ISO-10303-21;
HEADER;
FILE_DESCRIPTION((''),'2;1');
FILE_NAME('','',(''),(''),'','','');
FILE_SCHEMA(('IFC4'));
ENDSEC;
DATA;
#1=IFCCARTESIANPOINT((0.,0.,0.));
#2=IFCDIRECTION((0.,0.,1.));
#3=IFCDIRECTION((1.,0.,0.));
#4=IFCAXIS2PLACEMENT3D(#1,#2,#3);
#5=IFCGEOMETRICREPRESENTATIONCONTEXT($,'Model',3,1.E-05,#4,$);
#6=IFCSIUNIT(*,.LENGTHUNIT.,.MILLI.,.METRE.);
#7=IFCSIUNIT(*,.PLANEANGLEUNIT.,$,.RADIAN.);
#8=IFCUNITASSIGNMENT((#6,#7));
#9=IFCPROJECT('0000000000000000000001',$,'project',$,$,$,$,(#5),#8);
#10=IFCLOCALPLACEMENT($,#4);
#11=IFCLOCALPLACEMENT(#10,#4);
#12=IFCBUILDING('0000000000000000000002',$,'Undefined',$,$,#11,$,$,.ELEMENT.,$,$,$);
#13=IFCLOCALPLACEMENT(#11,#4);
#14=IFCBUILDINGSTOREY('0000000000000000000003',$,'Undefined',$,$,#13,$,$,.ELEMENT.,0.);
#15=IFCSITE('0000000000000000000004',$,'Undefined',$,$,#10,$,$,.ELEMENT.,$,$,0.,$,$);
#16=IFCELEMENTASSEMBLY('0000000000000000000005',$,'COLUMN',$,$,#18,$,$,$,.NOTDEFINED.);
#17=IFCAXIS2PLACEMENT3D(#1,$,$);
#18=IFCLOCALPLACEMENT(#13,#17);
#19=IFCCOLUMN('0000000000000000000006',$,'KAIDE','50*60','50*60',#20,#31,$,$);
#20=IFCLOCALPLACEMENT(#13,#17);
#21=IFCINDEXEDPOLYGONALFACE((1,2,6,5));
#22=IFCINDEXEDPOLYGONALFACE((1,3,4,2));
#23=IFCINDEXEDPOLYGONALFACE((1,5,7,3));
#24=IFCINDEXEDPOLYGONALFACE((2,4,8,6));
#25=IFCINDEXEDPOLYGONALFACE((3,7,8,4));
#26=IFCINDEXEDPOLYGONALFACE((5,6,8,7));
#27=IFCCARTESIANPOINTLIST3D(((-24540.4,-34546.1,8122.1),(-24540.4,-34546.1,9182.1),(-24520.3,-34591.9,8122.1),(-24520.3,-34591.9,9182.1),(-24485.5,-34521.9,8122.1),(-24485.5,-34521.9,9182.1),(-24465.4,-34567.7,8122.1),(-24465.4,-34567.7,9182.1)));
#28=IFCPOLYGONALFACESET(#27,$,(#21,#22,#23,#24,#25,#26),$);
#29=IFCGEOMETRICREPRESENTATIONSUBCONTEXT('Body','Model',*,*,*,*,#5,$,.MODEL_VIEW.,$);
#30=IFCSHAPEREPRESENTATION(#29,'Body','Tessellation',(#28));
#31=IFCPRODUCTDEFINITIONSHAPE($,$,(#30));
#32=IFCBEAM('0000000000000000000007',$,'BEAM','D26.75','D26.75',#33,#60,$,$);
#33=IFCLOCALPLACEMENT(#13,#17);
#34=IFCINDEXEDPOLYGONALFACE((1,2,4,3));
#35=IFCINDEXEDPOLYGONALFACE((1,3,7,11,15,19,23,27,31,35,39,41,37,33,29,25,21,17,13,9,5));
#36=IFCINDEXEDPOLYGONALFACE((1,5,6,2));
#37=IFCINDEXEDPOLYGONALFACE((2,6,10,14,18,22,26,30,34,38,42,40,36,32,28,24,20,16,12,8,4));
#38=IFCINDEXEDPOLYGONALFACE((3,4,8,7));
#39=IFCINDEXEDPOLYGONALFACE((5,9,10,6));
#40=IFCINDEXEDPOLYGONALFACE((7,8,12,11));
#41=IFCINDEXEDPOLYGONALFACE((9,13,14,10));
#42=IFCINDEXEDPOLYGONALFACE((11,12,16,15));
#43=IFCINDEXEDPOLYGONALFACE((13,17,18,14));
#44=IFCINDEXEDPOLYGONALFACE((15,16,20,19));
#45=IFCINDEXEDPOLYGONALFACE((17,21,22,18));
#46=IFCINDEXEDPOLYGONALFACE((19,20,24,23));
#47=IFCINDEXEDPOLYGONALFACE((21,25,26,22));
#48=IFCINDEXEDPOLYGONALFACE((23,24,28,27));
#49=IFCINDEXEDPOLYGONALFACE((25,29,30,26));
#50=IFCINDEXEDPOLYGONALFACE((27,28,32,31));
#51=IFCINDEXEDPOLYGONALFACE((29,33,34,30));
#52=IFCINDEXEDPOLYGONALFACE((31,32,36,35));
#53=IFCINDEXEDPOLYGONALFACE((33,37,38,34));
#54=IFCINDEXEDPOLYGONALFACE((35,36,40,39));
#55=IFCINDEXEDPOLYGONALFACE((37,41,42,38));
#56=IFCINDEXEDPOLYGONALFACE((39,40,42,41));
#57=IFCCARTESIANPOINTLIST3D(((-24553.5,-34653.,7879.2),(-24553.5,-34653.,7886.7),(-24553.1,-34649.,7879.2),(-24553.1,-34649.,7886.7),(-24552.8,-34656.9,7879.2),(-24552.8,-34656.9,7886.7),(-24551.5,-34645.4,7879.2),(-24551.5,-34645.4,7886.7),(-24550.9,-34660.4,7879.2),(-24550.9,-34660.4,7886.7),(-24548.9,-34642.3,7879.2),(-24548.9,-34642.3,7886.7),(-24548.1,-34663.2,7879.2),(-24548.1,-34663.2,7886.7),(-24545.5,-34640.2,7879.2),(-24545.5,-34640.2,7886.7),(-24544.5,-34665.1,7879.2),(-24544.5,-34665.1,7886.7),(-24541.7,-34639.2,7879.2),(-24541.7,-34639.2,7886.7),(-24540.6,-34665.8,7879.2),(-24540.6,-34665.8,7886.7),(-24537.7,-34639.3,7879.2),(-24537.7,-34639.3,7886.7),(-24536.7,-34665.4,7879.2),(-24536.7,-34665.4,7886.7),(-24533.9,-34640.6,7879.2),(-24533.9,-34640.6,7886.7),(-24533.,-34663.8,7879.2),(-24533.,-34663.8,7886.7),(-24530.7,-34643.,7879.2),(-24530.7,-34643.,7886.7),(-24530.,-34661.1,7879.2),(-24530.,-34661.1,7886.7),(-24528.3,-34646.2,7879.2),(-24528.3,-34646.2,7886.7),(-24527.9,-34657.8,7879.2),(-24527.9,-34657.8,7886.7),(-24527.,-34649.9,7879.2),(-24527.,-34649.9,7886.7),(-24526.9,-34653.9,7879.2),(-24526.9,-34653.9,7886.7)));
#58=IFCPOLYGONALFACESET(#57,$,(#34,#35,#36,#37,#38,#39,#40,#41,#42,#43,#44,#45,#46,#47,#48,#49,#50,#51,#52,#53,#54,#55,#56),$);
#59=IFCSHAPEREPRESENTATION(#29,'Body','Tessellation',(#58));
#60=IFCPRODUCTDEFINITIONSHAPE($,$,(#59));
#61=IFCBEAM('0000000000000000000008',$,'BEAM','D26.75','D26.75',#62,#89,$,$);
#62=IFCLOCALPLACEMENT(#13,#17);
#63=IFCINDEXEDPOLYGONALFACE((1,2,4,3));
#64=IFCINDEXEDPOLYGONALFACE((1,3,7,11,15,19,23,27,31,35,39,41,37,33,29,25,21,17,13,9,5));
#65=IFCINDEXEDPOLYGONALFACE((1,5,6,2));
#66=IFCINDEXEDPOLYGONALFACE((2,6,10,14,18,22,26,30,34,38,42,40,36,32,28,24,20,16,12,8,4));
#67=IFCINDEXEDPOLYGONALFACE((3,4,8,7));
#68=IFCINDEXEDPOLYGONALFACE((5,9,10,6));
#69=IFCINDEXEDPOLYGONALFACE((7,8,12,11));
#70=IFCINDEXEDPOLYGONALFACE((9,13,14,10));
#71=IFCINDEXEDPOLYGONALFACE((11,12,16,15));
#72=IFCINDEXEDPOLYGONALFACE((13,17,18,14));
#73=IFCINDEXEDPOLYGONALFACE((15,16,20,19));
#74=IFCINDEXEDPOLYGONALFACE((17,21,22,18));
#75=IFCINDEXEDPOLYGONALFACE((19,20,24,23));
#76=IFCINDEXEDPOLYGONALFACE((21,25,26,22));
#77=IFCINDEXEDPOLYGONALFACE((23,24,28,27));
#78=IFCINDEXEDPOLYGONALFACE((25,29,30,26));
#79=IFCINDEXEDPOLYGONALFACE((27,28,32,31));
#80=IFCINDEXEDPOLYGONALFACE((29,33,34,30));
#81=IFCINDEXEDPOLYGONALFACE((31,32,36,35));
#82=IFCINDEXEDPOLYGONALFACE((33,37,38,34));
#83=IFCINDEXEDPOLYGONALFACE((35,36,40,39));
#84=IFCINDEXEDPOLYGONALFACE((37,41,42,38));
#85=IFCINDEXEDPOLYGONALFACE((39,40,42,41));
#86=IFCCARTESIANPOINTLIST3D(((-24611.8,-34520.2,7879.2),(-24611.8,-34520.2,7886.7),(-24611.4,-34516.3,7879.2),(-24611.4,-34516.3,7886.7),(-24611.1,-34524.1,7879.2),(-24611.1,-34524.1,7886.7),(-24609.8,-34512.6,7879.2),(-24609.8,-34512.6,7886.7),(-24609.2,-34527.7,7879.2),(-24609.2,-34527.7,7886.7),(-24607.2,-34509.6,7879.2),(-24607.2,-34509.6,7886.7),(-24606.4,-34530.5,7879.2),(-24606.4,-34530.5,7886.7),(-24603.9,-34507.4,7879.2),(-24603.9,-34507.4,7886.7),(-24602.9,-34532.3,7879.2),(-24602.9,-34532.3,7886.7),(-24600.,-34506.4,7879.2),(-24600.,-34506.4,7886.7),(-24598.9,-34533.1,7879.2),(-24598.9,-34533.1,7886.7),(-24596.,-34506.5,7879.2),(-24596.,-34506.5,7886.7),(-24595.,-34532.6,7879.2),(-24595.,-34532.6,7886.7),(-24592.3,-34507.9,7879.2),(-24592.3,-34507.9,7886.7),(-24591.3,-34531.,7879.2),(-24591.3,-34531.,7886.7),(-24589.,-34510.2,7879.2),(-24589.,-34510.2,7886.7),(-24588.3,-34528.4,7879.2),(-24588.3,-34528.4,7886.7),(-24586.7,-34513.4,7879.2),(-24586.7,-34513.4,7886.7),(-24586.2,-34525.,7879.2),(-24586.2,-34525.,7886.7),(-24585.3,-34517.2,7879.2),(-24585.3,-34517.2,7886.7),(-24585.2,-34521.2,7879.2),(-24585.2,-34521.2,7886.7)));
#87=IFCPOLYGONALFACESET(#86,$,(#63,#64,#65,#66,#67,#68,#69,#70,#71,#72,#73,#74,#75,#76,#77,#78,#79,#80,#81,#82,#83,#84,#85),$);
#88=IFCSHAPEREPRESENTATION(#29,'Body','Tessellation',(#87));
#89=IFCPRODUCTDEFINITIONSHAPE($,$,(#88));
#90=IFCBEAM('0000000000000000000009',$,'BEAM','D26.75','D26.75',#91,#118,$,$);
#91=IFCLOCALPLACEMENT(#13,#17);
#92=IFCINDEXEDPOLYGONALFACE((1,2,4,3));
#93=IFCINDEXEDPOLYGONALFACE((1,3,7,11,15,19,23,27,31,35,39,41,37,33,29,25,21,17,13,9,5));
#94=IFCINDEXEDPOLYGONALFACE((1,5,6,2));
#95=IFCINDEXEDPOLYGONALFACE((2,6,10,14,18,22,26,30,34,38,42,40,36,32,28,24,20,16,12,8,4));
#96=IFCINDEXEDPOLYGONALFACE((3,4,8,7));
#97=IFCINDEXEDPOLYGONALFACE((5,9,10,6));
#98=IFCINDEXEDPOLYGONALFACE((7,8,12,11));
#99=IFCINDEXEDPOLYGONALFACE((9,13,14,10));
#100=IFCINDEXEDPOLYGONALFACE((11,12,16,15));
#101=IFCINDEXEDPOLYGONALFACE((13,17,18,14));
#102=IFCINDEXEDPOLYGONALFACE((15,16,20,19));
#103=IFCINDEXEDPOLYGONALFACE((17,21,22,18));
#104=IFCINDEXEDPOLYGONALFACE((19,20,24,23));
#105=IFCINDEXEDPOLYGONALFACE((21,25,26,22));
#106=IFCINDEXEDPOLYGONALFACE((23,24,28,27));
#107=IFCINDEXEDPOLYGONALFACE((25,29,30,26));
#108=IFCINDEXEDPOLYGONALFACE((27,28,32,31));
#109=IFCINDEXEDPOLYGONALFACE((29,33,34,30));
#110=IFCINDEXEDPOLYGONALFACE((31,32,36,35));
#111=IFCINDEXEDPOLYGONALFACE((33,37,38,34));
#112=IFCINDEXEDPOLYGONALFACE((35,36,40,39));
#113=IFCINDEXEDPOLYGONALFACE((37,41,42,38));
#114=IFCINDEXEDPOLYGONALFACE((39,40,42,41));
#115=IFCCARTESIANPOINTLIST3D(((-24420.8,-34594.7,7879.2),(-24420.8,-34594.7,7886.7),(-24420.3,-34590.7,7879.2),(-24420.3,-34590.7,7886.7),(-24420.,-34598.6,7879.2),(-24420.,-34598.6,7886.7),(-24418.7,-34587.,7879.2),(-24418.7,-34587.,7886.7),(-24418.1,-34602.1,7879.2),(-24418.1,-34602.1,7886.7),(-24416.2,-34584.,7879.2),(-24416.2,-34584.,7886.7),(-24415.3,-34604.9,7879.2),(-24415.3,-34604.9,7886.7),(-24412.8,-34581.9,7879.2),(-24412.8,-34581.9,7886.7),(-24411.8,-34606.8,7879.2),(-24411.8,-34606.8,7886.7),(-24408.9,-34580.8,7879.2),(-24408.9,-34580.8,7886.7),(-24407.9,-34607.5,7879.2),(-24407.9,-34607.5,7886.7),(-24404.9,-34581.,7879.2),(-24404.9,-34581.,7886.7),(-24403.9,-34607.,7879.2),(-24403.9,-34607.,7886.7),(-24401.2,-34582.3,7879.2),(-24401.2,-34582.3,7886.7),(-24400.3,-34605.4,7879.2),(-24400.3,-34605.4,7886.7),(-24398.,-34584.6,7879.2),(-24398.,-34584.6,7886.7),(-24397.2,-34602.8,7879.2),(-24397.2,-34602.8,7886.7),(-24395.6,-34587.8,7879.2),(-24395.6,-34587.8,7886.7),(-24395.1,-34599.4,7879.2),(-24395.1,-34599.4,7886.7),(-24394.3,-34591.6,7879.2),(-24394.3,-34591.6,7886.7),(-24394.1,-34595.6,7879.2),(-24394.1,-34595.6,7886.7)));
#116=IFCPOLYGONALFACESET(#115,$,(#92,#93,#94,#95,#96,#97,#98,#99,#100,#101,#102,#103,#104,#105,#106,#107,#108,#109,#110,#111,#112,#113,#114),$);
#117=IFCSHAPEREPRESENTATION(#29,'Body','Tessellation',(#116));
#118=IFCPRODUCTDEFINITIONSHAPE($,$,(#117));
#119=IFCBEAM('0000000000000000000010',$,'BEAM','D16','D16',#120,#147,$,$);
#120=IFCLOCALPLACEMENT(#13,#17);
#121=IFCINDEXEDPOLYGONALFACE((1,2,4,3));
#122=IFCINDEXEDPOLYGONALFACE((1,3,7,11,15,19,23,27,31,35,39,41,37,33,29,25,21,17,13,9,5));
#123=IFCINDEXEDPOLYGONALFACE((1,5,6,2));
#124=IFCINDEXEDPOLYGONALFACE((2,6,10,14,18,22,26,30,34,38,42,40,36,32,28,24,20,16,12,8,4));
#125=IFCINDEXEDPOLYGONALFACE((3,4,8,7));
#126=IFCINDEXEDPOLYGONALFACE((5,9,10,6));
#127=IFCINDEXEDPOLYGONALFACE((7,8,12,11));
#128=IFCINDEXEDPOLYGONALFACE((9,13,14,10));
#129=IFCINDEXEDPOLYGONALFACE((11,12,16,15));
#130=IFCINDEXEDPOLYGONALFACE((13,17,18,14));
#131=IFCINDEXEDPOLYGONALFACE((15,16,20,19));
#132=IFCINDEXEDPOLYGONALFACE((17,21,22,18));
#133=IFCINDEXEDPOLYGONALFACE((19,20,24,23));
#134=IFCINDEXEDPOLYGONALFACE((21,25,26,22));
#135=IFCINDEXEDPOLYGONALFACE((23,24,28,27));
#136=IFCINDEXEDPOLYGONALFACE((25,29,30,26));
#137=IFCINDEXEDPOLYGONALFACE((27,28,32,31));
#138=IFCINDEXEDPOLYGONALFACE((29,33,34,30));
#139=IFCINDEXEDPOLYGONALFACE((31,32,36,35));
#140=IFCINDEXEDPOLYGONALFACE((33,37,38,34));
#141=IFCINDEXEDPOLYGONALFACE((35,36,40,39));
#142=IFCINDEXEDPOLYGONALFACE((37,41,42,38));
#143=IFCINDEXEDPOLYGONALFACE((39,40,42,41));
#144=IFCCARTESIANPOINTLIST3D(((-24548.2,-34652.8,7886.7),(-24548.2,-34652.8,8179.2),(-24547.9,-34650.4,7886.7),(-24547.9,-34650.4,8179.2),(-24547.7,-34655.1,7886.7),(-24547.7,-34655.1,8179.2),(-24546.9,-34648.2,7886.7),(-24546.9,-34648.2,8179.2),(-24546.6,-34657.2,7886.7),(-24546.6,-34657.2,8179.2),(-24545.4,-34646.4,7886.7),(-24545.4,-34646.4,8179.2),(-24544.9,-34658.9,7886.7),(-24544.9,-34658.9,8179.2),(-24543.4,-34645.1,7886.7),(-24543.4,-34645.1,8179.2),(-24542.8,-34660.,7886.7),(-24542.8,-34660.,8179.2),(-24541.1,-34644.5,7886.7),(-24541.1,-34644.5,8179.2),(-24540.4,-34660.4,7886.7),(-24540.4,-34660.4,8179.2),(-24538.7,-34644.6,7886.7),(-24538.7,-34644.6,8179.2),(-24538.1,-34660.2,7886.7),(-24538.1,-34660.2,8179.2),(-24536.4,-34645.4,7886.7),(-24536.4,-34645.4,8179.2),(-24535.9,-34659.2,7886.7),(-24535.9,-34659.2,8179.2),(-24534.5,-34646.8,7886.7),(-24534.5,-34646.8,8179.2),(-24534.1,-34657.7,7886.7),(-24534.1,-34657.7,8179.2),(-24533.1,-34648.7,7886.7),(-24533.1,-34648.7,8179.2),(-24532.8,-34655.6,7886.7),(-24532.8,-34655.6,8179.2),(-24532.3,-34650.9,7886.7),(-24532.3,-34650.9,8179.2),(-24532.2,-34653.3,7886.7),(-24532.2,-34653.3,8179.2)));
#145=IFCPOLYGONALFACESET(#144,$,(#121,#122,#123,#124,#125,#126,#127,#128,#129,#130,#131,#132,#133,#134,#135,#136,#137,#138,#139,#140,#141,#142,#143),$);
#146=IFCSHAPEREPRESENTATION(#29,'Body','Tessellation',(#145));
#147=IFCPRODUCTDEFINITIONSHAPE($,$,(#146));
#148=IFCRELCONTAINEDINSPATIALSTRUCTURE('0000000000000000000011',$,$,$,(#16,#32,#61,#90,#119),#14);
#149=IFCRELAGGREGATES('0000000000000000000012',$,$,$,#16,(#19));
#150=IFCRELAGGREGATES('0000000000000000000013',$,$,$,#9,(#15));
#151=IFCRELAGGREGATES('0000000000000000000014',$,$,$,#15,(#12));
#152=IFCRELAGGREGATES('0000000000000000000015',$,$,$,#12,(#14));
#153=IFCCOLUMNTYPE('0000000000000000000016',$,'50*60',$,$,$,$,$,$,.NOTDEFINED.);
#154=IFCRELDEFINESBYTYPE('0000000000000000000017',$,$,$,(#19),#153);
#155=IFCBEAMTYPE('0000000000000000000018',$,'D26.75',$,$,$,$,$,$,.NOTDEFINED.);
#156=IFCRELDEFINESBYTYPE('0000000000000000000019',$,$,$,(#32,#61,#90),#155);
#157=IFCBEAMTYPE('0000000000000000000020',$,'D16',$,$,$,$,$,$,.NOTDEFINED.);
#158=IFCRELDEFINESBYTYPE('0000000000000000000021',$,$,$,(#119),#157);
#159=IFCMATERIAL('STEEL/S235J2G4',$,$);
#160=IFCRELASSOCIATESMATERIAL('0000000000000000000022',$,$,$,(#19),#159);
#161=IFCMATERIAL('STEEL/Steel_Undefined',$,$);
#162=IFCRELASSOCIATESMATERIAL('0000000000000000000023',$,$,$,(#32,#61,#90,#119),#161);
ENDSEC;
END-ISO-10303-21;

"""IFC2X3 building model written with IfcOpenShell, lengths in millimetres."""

from ifc_helpers import new_model, si_unit, frame, origin_with_axes, origin_2d_with_axis, place, context, subcontext, project, spatial, rectangle, circle, extrude, material, type_object, element, aggregate, save


model = new_model("IFC2X3")

# Units and contexts
model_context = context("Model", 3, precision=1e-05, world=origin_with_axes())
body_context = subcontext(model_context, "Body", "Model", "MODEL_VIEW")
ifc_project = project(units=[si_unit("LENGTHUNIT", "METRE", prefix="MILLI"), si_unit("PLANEANGLEUNIT", "RADIAN")], contexts=[model_context])

# Site, building, storey
site_placement = place(None, origin_with_axes())
site = spatial("IfcSite", under=ifc_project, at=site_placement, Name="Undefined", CompositionType="ELEMENT", RefElevation=0.0)
building_placement = place(site_placement, origin_with_axes())
building = spatial("IfcBuilding", under=site, at=building_placement, Name="Undefined", CompositionType="ELEMENT")
storey_placement = place(building_placement, origin_with_axes())
storey = spatial("IfcBuildingStorey", under=building, at=storey_placement, Name="Undefined", CompositionType="ELEMENT", Elevation=0.0)

# Element assembly, column
assembly_placement = place(storey_placement, frame((-24502.9, -34556.9, 8122.1), z_axis=(-0.402198, 0.915553, 0.0), x_axis=(0.0, 0.0, 1.0)))
assembly = element("IfcElementAssembly", 1, at=assembly_placement, inside=storey, Name="COLUMN", PredefinedType="NOTDEFINED")
ifc_material_1 = material(Name="STEEL/S235J2G4")
column_type = type_object("IfcColumnType", Name="50*60", PredefinedType="NOTDEFINED")
column_placement = place(storey_placement, frame((-24502.9, -34556.9, 8122.1), z_axis=(0.0, 0.0, 1.0), x_axis=(1.0, 0.0, 0.0)))
column = element("IfcColumn", 2, at=column_placement, type_object=column_type, material=ifc_material_1, Name="KAIDE", Description="50*60", ObjectType="50*60", context=body_context, shape_type="SweptSolid", body=[
    extrude(rectangle(XDim=60.0, YDim=50.0, at=origin_2d_with_axis()), frame((0.0, 0.0, 1060.0), z_axis=(0.0, 0.0, -1.0), x_axis=(-0.915553, -0.402198, 0.0)), (0.0, 0.0, 1.0), 1060.0),
])
aggregate(assembly, [column])

# Shared definitions
ifc_material_2 = material(Name="STEEL/Steel_Undefined")
beam_type_1 = type_object("IfcBeamType", Name="D26.75", PredefinedType="NOTDEFINED")

# Beam
beam_1_placement = place(storey_placement, frame((-24540.2, -34652.4, 7886.7), z_axis=(-0.915553, -0.402198, 0.0), x_axis=(0.0, 0.0, -1.0)))
element("IfcBeam", 3, at=beam_1_placement, inside=storey, type_object=beam_type_1, material=ifc_material_2, Name="BEAM", Description="D26.75", ObjectType="D26.75", context=body_context, shape_type="SweptSolid", body=[
    extrude(circle(Radius=13.4, at=origin_2d_with_axis()), frame((7.4, 0.0, 0.0), z_axis=(-1.0, 0.0, 0.0), x_axis=(0.0, -1.0, 0.0)), (0.0, 0.0, 1.0), 7.4),
])

# Beam
beam_2_placement = place(storey_placement, frame((-24598.5, -34519.7, 7886.7), z_axis=(-0.915553, -0.402198, 0.0), x_axis=(0.0, 0.0, -1.0)))
element("IfcBeam", 4, at=beam_2_placement, inside=storey, type_object=beam_type_1, material=ifc_material_2, Name="BEAM", Description="D26.75", ObjectType="D26.75", context=body_context, shape_type="SweptSolid", body=[
    extrude(circle(Radius=13.4, at=origin_2d_with_axis()), frame((7.4, 0.0, 0.0), z_axis=(-1.0, 0.0, 0.0), x_axis=(0.0, -1.0, 0.0)), (0.0, 0.0, 1.0), 7.4),
])

# Beam
beam_3_placement = place(storey_placement, frame((-24407.4, -34594.1, 7886.7), z_axis=(-0.915553, -0.402198, 0.0), x_axis=(0.0, 0.0, -1.0)))
element("IfcBeam", 5, at=beam_3_placement, inside=storey, type_object=beam_type_1, material=ifc_material_2, Name="BEAM", Description="D26.75", ObjectType="D26.75", context=body_context, shape_type="SweptSolid", body=[
    extrude(circle(Radius=13.4, at=origin_2d_with_axis()), frame((7.4, 0.0, 0.0), z_axis=(-1.0, 0.0, 0.0), x_axis=(0.0, -1.0, 0.0)), (0.0, 0.0, 1.0), 7.4),
])

# Beam
beam_type_2 = type_object("IfcBeamType", Name="D16", PredefinedType="NOTDEFINED")
beam_4_placement = place(storey_placement, frame((-24540.2, -34652.4, 8179.2), z_axis=(-0.915553, -0.402198, 0.0), x_axis=(0.0, 0.0, -1.0)))
element("IfcBeam", 6, at=beam_4_placement, inside=storey, type_object=beam_type_2, material=ifc_material_2, Name="BEAM", Description="D16", ObjectType="D16", context=body_context, shape_type="SweptSolid", body=[
    extrude(circle(Radius=8.0, at=origin_2d_with_axis()), frame((292.6, 0.0, 0.0), z_axis=(-1.0, 0.0, 0.0), x_axis=(0.0, -1.0, 0.0)), (0.0, 0.0, 1.0), 292.6),
])

save(model, "model.ifc")
